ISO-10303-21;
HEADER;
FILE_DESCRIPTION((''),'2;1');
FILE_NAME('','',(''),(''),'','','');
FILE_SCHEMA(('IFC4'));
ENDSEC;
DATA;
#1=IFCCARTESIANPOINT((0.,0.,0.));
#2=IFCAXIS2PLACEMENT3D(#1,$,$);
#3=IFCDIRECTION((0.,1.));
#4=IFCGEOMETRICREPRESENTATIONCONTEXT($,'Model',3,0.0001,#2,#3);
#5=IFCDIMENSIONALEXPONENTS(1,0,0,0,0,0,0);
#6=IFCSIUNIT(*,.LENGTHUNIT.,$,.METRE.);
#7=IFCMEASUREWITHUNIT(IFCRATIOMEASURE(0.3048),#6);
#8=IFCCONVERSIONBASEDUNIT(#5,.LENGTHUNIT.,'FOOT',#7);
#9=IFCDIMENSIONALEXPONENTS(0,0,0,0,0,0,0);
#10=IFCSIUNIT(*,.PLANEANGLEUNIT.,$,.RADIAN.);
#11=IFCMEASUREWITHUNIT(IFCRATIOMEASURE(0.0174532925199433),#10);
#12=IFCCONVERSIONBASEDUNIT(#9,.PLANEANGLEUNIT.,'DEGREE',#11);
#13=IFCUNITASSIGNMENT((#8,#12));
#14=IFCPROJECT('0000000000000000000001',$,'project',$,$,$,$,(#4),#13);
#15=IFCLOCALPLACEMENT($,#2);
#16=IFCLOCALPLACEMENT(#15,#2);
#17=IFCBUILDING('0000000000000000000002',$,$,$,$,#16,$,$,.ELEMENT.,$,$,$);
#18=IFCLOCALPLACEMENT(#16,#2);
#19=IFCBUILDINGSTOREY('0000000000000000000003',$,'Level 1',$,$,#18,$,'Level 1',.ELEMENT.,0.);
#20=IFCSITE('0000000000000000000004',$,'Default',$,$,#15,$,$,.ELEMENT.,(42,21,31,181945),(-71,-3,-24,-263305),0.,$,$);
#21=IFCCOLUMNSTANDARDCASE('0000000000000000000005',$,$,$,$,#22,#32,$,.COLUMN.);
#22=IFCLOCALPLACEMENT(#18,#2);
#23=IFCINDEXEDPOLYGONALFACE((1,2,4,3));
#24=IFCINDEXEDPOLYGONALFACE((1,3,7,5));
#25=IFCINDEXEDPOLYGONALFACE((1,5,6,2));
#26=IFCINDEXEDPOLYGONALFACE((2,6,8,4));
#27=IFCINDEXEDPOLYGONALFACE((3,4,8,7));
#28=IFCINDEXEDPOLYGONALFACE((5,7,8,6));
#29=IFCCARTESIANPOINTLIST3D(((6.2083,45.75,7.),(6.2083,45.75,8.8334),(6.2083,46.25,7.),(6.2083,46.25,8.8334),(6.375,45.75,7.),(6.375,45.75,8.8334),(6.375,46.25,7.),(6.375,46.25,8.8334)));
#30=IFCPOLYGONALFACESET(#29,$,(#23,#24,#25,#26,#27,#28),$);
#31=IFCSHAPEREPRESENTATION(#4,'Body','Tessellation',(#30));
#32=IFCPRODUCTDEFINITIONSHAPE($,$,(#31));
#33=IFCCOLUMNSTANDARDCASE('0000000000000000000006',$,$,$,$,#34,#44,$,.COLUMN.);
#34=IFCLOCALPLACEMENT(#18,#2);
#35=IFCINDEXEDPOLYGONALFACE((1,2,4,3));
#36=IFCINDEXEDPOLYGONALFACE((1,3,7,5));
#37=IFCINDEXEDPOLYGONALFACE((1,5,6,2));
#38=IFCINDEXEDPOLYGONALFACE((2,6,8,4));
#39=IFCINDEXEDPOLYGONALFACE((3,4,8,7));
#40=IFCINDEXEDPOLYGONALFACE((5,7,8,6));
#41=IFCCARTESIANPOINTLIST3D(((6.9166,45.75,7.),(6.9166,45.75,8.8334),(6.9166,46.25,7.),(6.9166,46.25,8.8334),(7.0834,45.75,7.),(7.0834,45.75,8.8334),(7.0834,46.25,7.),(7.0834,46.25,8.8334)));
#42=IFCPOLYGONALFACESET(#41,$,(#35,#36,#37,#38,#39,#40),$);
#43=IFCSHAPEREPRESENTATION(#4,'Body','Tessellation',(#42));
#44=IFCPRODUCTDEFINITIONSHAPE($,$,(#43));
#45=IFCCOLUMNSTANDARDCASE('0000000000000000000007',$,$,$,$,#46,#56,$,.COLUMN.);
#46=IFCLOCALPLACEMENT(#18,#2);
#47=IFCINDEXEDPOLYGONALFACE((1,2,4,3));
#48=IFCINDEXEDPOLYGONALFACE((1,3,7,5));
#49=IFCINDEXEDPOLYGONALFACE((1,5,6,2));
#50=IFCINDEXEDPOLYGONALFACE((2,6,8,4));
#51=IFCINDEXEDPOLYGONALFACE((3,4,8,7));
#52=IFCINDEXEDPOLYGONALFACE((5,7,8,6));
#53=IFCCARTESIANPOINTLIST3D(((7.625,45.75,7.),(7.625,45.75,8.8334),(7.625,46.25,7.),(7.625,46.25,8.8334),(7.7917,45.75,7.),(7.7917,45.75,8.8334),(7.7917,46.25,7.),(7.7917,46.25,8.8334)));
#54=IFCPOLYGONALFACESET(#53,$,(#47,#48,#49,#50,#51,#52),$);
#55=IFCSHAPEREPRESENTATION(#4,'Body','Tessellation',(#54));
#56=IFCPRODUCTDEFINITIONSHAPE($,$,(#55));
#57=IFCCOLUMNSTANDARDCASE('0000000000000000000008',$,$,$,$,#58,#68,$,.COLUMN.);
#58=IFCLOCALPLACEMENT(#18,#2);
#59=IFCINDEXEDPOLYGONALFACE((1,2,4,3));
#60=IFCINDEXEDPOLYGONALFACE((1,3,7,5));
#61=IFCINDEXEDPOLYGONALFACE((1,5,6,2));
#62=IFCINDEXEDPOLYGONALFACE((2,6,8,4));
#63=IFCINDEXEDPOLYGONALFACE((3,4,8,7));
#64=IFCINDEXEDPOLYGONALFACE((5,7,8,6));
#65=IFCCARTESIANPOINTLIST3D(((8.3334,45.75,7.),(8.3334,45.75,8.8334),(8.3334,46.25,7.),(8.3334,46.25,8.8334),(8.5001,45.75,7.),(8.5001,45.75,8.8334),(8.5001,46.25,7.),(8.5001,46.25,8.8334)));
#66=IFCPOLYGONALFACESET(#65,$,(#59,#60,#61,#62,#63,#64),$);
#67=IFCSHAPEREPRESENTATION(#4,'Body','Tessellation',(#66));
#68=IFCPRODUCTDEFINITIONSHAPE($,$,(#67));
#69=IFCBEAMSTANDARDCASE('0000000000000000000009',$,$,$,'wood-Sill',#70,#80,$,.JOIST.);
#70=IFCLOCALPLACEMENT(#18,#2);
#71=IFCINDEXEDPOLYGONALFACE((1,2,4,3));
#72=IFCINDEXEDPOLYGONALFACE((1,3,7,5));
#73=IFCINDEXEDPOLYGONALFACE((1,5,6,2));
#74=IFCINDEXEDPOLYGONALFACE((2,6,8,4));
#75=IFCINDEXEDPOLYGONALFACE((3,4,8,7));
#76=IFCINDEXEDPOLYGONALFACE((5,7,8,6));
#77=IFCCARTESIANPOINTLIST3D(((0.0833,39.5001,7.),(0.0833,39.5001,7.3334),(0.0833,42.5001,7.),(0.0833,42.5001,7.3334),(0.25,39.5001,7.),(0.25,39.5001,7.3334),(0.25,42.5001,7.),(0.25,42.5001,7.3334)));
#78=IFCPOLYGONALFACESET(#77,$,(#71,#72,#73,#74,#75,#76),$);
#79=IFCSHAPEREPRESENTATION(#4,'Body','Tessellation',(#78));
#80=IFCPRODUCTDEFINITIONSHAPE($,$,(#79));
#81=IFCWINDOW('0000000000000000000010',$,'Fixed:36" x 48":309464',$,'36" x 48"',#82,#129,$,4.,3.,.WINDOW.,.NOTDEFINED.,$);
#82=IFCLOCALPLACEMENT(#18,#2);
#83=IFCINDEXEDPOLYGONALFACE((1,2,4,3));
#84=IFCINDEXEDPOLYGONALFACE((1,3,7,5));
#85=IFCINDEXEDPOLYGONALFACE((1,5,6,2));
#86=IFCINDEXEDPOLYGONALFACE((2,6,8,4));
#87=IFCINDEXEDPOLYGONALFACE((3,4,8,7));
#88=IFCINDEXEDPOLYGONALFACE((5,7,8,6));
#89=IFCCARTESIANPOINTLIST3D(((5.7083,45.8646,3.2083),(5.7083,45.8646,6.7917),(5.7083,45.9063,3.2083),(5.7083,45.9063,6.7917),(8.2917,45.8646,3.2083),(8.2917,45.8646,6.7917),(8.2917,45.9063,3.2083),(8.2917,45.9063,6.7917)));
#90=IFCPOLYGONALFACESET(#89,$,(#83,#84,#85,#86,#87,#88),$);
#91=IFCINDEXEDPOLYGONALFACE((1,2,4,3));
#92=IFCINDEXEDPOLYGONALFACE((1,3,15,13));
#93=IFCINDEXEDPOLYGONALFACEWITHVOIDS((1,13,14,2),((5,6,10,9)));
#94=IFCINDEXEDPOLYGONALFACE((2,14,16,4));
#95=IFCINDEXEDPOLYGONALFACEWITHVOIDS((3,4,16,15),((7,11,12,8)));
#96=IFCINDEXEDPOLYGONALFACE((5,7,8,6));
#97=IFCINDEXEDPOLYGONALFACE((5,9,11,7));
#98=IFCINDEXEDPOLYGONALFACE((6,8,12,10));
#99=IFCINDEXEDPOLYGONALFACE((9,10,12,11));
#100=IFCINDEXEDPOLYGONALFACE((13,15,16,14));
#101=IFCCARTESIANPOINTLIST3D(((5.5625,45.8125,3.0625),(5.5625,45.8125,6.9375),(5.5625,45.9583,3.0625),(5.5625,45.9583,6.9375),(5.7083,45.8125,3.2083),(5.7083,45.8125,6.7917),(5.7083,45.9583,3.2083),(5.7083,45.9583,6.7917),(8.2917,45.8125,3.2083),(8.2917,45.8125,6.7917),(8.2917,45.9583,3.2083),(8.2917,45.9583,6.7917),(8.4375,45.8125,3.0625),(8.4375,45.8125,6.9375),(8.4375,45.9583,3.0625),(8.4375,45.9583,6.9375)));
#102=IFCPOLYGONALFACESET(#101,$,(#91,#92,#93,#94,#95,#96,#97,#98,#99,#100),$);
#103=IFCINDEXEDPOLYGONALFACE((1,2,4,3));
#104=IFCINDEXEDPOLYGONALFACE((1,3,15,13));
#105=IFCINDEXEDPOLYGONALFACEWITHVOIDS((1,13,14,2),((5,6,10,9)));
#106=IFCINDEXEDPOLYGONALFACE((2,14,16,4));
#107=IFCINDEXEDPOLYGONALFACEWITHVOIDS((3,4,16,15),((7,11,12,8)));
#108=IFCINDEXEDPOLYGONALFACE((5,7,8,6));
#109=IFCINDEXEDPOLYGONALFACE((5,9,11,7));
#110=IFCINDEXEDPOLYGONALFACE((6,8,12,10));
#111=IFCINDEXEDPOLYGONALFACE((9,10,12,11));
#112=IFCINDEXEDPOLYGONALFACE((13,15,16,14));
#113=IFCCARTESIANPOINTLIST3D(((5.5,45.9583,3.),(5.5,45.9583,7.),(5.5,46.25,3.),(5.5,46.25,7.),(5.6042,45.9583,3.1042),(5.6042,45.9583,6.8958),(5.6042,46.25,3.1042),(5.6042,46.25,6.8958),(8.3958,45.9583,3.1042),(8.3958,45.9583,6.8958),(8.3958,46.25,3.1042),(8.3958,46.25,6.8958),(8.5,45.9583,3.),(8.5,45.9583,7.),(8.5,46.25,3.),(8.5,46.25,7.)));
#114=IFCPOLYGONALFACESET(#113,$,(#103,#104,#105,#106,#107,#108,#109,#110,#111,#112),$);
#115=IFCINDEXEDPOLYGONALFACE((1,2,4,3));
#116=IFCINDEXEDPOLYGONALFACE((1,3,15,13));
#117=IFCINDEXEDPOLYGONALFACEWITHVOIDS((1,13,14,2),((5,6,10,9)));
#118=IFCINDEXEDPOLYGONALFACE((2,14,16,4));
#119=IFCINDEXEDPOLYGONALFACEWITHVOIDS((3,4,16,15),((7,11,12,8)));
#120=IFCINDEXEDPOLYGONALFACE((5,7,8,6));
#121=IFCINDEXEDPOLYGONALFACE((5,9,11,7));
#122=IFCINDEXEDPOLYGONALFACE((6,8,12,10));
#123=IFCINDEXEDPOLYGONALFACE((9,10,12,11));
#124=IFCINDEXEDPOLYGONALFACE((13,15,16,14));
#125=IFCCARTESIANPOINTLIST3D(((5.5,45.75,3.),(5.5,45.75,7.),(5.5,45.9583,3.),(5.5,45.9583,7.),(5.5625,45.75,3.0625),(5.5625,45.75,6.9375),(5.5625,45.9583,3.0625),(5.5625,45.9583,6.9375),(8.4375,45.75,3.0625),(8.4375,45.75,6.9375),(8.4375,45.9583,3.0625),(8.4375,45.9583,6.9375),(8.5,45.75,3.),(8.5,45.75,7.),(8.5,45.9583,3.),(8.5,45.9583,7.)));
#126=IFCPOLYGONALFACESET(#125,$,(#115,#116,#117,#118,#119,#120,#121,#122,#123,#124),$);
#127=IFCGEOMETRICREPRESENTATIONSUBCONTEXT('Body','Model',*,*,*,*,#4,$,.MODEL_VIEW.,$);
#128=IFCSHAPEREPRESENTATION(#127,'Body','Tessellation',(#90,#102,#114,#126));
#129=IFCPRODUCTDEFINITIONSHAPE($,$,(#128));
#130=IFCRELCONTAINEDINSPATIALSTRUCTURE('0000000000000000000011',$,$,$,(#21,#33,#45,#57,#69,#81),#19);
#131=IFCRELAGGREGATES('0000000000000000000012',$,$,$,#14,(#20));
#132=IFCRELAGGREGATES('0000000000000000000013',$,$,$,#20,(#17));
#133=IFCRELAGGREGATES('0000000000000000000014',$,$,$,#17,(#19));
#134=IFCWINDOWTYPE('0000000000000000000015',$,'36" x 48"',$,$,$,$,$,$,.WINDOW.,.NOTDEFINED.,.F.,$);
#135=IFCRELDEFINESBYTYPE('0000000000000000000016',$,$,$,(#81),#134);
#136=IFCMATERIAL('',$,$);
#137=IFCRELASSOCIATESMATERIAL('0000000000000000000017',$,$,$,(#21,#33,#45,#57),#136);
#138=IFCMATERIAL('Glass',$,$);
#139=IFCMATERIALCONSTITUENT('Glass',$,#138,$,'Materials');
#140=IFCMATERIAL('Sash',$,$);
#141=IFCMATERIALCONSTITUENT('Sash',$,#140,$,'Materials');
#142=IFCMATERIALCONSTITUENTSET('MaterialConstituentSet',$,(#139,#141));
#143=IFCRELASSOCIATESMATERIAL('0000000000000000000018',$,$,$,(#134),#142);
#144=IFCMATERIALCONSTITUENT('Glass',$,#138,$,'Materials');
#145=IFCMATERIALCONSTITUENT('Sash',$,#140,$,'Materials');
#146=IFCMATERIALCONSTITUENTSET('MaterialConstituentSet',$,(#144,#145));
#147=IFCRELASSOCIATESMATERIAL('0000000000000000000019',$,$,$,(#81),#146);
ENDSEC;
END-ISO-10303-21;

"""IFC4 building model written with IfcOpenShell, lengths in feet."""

from ifc_helpers import new_model, entity, si_unit, converted_unit, direction, frame, frame_2d, origin, origin_with_axes, place, context, subcontext, project, spatial, polyline, rectangle, outline, extrude, source, transform, mapped, material, constituent, constituent_set, type_object, type_shapes, element, save


model = new_model("IFC4")

# Units and contexts
model_context = context("Model", 3, precision=0.0001, world=origin(), true_north=direction((0.0, 1.0)))
body_context = subcontext(model_context, "Body", "Model", "MODEL_VIEW")
ifc_project = project(units=[converted_unit("LENGTHUNIT", "FOOT", entity("IfcRatioMeasure", 0.3048), si_unit("LENGTHUNIT", "METRE"), dimensions=[1, 0, 0, 0, 0, 0, 0]), converted_unit("PLANEANGLEUNIT", "DEGREE", entity("IfcRatioMeasure", 0.0174532925199433), si_unit("PLANEANGLEUNIT", "RADIAN"), dimensions=[0, 0, 0, 0, 0, 0, 0])], contexts=[model_context])

# Site, building, storey
site_placement = place(None, origin())
site = spatial("IfcSite", under=ifc_project, at=site_placement, Name="Default", CompositionType="ELEMENT", RefLatitude=(42, 21, 31, 181945), RefLongitude=(-71, -3, -24, -263305), RefElevation=0.0)
building_placement = place(site_placement, origin())
building = spatial("IfcBuilding", under=site, at=building_placement, CompositionType="ELEMENT")
storey_placement = place(building_placement, origin())
storey = spatial("IfcBuildingStorey", under=building, at=storey_placement, Name="Level 1", LongName="Level 1", CompositionType="ELEMENT", Elevation=0.0)

# Columns
placement_1 = place(storey_placement, frame((-0.25, 46.0, 0.0)))
ifc_material_1 = material(Name="")
for number, where, z_axis, x_axis in (
    (1, (6.5417, 0.0, 7.0), (0.0, 0.0, 1.0), (1.0, 0.0, 0.0)),
    (2, (7.25, 0.0, 7.0), (0.0, 0.0, 1.0), (1.0, 0.0, 0.0)),
    (3, (7.9583, 0.0, 7.0), (0.0, 0.0, 1.0), (1.0, 0.0, 0.0)),
    (4, (8.6667, 0.0, 7.0), (0.0, 0.0, 1.0), (1.0, 0.0, 0.0)),
):
    element("IfcColumnStandardCase", number, at=place(placement_1, frame(where, z_axis=z_axis, x_axis=x_axis)), inside=storey, material=ifc_material_1, PredefinedType="COLUMN", context=model_context, shape_type="SweptSolid", body=[
        extrude(rectangle(XDim=0.1667, YDim=0.5), origin(), (0.0, 0.0, 1.0), 1.8334),
    ])

# Beam
placement_2 = place(storey_placement, frame((0.0, -0.25, 0.0), z_axis=(0.0, 0.0, 1.0), x_axis=(0.0, 1.0, 0.0)))
beam_placement = place(placement_2, frame((39.7501, -0.1667, 7.1667), z_axis=(1.0, 0.0, 0.0), x_axis=(0.0, 0.0, 1.0)))
element("IfcBeamStandardCase", 5, at=beam_placement, inside=storey, ObjectType="wood-Sill", PredefinedType="JOIST", context=model_context, shape_type="SweptSolid", body=[
    extrude(rectangle(XDim=0.3333, YDim=0.1667), origin_with_axes(), (0.0, 0.0, 1.0), 3.0),
])

# Window
ifc_material_2 = material(Name="Glass")
ifc_constituent_1 = constituent(ifc_material_2, Name="Glass", Category="Materials")
ifc_material_3 = material(Name="Sash")
ifc_constituent_2 = constituent(ifc_material_3, Name="Sash", Category="Materials")
ifc_constituent_set_1 = constituent_set(constituents=[ifc_constituent_1, ifc_constituent_2], Name="MaterialConstituentSet")
ifc_constituent_3 = constituent(ifc_material_2, Name="Glass", Category="Materials")
ifc_constituent_4 = constituent(ifc_material_3, Name="Sash", Category="Materials")
ifc_constituent_set_2 = constituent_set(constituents=[ifc_constituent_3, ifc_constituent_4], Name="MaterialConstituentSet")
window_type = type_object("IfcWindowType", Name="36\" x 48\"", ParameterTakesPrecedence=False, PartitioningType="NOTDEFINED", PredefinedType="WINDOW", material=ifc_constituent_set_2)
shared_shape = source(origin(), body_context, "Body", "SweptSolid", [
    extrude(rectangle(XDim=0.0417, YDim=2.5833, at=frame_2d((0.0, 0.0), x_axis=(1.0, 0.0))), frame((1.5, 0.3646, 0.2083), z_axis=(0.0, 0.0, 1.0), x_axis=(0.0, 1.0, 0.0)), (0.0, 0.0, 1.0), 3.5833),
    extrude(outline(polyline([(-1.4375, -1.9375), (1.4375, -1.9375), (1.4375, 1.9375), (-1.4375, 1.9375), (-1.4375, -1.9375)]), holes=[polyline([(-1.2917, -1.7917), (-1.2917, 1.7917), (1.2917, 1.7917), (1.2917, -1.7917), (-1.2917, -1.7917)])]), frame((1.5, 0.2917, 2.0), z_axis=(0.0, 1.0, 0.0), x_axis=(1.0, 0.0, 0.0)), (0.0, 0.0, 1.0), 0.1458),
    extrude(outline(polyline([(-1.5, -2.0), (1.5, -2.0), (1.5, 2.0), (-1.5, 2.0), (-1.5, -2.0)]), holes=[polyline([(-1.3958, -1.8958), (-1.3958, 1.8958), (1.3958, 1.8958), (1.3958, -1.8958), (-1.3958, -1.8958)])]), frame((1.5, 0.0, 2.0), z_axis=(0.0, 1.0, 0.0), x_axis=(1.0, 0.0, 0.0)), (0.0, 0.0, 1.0), 0.2917),
    extrude(outline(polyline([(-2.0, -1.5), (2.0, -1.5), (2.0, 1.5), (-2.0, 1.5), (-2.0, -1.5)]), holes=[polyline([(-1.9375, -1.4375), (-1.9375, 1.4375), (1.9375, 1.4375), (1.9375, -1.4375), (-1.9375, -1.4375)])]), frame((1.5, 0.2917, 2.0), z_axis=(0.0, 1.0, 0.0), x_axis=(0.0, 0.0, -1.0)), (0.0, 0.0, 1.0), 0.2083),
])
type_shapes(window_type, [shared_shape])
placement_3 = place(placement_1, frame((8.75, 0.25, 3.0)))
window_placement = place(placement_3, frame((0.0, 0.0, 0.0), z_axis=(0.0, 0.0, 1.0), x_axis=(-1.0, 0.0, 0.0)))
element("IfcWindow", 6, at=window_placement, inside=storey, type_object=window_type, material=ifc_constituent_set_1, Name="Fixed:36\" x 48\":309464", ObjectType="36\" x 48\"", OverallHeight=4.0, OverallWidth=3.0, PartitioningType="NOTDEFINED", PredefinedType="WINDOW", context=body_context, shape_type="MappedRepresentation", body=[
    mapped(shared_shape, transform((0.0, 0.0, 0.0), scale=1.0)),
])

save(model, "model.ifc")
